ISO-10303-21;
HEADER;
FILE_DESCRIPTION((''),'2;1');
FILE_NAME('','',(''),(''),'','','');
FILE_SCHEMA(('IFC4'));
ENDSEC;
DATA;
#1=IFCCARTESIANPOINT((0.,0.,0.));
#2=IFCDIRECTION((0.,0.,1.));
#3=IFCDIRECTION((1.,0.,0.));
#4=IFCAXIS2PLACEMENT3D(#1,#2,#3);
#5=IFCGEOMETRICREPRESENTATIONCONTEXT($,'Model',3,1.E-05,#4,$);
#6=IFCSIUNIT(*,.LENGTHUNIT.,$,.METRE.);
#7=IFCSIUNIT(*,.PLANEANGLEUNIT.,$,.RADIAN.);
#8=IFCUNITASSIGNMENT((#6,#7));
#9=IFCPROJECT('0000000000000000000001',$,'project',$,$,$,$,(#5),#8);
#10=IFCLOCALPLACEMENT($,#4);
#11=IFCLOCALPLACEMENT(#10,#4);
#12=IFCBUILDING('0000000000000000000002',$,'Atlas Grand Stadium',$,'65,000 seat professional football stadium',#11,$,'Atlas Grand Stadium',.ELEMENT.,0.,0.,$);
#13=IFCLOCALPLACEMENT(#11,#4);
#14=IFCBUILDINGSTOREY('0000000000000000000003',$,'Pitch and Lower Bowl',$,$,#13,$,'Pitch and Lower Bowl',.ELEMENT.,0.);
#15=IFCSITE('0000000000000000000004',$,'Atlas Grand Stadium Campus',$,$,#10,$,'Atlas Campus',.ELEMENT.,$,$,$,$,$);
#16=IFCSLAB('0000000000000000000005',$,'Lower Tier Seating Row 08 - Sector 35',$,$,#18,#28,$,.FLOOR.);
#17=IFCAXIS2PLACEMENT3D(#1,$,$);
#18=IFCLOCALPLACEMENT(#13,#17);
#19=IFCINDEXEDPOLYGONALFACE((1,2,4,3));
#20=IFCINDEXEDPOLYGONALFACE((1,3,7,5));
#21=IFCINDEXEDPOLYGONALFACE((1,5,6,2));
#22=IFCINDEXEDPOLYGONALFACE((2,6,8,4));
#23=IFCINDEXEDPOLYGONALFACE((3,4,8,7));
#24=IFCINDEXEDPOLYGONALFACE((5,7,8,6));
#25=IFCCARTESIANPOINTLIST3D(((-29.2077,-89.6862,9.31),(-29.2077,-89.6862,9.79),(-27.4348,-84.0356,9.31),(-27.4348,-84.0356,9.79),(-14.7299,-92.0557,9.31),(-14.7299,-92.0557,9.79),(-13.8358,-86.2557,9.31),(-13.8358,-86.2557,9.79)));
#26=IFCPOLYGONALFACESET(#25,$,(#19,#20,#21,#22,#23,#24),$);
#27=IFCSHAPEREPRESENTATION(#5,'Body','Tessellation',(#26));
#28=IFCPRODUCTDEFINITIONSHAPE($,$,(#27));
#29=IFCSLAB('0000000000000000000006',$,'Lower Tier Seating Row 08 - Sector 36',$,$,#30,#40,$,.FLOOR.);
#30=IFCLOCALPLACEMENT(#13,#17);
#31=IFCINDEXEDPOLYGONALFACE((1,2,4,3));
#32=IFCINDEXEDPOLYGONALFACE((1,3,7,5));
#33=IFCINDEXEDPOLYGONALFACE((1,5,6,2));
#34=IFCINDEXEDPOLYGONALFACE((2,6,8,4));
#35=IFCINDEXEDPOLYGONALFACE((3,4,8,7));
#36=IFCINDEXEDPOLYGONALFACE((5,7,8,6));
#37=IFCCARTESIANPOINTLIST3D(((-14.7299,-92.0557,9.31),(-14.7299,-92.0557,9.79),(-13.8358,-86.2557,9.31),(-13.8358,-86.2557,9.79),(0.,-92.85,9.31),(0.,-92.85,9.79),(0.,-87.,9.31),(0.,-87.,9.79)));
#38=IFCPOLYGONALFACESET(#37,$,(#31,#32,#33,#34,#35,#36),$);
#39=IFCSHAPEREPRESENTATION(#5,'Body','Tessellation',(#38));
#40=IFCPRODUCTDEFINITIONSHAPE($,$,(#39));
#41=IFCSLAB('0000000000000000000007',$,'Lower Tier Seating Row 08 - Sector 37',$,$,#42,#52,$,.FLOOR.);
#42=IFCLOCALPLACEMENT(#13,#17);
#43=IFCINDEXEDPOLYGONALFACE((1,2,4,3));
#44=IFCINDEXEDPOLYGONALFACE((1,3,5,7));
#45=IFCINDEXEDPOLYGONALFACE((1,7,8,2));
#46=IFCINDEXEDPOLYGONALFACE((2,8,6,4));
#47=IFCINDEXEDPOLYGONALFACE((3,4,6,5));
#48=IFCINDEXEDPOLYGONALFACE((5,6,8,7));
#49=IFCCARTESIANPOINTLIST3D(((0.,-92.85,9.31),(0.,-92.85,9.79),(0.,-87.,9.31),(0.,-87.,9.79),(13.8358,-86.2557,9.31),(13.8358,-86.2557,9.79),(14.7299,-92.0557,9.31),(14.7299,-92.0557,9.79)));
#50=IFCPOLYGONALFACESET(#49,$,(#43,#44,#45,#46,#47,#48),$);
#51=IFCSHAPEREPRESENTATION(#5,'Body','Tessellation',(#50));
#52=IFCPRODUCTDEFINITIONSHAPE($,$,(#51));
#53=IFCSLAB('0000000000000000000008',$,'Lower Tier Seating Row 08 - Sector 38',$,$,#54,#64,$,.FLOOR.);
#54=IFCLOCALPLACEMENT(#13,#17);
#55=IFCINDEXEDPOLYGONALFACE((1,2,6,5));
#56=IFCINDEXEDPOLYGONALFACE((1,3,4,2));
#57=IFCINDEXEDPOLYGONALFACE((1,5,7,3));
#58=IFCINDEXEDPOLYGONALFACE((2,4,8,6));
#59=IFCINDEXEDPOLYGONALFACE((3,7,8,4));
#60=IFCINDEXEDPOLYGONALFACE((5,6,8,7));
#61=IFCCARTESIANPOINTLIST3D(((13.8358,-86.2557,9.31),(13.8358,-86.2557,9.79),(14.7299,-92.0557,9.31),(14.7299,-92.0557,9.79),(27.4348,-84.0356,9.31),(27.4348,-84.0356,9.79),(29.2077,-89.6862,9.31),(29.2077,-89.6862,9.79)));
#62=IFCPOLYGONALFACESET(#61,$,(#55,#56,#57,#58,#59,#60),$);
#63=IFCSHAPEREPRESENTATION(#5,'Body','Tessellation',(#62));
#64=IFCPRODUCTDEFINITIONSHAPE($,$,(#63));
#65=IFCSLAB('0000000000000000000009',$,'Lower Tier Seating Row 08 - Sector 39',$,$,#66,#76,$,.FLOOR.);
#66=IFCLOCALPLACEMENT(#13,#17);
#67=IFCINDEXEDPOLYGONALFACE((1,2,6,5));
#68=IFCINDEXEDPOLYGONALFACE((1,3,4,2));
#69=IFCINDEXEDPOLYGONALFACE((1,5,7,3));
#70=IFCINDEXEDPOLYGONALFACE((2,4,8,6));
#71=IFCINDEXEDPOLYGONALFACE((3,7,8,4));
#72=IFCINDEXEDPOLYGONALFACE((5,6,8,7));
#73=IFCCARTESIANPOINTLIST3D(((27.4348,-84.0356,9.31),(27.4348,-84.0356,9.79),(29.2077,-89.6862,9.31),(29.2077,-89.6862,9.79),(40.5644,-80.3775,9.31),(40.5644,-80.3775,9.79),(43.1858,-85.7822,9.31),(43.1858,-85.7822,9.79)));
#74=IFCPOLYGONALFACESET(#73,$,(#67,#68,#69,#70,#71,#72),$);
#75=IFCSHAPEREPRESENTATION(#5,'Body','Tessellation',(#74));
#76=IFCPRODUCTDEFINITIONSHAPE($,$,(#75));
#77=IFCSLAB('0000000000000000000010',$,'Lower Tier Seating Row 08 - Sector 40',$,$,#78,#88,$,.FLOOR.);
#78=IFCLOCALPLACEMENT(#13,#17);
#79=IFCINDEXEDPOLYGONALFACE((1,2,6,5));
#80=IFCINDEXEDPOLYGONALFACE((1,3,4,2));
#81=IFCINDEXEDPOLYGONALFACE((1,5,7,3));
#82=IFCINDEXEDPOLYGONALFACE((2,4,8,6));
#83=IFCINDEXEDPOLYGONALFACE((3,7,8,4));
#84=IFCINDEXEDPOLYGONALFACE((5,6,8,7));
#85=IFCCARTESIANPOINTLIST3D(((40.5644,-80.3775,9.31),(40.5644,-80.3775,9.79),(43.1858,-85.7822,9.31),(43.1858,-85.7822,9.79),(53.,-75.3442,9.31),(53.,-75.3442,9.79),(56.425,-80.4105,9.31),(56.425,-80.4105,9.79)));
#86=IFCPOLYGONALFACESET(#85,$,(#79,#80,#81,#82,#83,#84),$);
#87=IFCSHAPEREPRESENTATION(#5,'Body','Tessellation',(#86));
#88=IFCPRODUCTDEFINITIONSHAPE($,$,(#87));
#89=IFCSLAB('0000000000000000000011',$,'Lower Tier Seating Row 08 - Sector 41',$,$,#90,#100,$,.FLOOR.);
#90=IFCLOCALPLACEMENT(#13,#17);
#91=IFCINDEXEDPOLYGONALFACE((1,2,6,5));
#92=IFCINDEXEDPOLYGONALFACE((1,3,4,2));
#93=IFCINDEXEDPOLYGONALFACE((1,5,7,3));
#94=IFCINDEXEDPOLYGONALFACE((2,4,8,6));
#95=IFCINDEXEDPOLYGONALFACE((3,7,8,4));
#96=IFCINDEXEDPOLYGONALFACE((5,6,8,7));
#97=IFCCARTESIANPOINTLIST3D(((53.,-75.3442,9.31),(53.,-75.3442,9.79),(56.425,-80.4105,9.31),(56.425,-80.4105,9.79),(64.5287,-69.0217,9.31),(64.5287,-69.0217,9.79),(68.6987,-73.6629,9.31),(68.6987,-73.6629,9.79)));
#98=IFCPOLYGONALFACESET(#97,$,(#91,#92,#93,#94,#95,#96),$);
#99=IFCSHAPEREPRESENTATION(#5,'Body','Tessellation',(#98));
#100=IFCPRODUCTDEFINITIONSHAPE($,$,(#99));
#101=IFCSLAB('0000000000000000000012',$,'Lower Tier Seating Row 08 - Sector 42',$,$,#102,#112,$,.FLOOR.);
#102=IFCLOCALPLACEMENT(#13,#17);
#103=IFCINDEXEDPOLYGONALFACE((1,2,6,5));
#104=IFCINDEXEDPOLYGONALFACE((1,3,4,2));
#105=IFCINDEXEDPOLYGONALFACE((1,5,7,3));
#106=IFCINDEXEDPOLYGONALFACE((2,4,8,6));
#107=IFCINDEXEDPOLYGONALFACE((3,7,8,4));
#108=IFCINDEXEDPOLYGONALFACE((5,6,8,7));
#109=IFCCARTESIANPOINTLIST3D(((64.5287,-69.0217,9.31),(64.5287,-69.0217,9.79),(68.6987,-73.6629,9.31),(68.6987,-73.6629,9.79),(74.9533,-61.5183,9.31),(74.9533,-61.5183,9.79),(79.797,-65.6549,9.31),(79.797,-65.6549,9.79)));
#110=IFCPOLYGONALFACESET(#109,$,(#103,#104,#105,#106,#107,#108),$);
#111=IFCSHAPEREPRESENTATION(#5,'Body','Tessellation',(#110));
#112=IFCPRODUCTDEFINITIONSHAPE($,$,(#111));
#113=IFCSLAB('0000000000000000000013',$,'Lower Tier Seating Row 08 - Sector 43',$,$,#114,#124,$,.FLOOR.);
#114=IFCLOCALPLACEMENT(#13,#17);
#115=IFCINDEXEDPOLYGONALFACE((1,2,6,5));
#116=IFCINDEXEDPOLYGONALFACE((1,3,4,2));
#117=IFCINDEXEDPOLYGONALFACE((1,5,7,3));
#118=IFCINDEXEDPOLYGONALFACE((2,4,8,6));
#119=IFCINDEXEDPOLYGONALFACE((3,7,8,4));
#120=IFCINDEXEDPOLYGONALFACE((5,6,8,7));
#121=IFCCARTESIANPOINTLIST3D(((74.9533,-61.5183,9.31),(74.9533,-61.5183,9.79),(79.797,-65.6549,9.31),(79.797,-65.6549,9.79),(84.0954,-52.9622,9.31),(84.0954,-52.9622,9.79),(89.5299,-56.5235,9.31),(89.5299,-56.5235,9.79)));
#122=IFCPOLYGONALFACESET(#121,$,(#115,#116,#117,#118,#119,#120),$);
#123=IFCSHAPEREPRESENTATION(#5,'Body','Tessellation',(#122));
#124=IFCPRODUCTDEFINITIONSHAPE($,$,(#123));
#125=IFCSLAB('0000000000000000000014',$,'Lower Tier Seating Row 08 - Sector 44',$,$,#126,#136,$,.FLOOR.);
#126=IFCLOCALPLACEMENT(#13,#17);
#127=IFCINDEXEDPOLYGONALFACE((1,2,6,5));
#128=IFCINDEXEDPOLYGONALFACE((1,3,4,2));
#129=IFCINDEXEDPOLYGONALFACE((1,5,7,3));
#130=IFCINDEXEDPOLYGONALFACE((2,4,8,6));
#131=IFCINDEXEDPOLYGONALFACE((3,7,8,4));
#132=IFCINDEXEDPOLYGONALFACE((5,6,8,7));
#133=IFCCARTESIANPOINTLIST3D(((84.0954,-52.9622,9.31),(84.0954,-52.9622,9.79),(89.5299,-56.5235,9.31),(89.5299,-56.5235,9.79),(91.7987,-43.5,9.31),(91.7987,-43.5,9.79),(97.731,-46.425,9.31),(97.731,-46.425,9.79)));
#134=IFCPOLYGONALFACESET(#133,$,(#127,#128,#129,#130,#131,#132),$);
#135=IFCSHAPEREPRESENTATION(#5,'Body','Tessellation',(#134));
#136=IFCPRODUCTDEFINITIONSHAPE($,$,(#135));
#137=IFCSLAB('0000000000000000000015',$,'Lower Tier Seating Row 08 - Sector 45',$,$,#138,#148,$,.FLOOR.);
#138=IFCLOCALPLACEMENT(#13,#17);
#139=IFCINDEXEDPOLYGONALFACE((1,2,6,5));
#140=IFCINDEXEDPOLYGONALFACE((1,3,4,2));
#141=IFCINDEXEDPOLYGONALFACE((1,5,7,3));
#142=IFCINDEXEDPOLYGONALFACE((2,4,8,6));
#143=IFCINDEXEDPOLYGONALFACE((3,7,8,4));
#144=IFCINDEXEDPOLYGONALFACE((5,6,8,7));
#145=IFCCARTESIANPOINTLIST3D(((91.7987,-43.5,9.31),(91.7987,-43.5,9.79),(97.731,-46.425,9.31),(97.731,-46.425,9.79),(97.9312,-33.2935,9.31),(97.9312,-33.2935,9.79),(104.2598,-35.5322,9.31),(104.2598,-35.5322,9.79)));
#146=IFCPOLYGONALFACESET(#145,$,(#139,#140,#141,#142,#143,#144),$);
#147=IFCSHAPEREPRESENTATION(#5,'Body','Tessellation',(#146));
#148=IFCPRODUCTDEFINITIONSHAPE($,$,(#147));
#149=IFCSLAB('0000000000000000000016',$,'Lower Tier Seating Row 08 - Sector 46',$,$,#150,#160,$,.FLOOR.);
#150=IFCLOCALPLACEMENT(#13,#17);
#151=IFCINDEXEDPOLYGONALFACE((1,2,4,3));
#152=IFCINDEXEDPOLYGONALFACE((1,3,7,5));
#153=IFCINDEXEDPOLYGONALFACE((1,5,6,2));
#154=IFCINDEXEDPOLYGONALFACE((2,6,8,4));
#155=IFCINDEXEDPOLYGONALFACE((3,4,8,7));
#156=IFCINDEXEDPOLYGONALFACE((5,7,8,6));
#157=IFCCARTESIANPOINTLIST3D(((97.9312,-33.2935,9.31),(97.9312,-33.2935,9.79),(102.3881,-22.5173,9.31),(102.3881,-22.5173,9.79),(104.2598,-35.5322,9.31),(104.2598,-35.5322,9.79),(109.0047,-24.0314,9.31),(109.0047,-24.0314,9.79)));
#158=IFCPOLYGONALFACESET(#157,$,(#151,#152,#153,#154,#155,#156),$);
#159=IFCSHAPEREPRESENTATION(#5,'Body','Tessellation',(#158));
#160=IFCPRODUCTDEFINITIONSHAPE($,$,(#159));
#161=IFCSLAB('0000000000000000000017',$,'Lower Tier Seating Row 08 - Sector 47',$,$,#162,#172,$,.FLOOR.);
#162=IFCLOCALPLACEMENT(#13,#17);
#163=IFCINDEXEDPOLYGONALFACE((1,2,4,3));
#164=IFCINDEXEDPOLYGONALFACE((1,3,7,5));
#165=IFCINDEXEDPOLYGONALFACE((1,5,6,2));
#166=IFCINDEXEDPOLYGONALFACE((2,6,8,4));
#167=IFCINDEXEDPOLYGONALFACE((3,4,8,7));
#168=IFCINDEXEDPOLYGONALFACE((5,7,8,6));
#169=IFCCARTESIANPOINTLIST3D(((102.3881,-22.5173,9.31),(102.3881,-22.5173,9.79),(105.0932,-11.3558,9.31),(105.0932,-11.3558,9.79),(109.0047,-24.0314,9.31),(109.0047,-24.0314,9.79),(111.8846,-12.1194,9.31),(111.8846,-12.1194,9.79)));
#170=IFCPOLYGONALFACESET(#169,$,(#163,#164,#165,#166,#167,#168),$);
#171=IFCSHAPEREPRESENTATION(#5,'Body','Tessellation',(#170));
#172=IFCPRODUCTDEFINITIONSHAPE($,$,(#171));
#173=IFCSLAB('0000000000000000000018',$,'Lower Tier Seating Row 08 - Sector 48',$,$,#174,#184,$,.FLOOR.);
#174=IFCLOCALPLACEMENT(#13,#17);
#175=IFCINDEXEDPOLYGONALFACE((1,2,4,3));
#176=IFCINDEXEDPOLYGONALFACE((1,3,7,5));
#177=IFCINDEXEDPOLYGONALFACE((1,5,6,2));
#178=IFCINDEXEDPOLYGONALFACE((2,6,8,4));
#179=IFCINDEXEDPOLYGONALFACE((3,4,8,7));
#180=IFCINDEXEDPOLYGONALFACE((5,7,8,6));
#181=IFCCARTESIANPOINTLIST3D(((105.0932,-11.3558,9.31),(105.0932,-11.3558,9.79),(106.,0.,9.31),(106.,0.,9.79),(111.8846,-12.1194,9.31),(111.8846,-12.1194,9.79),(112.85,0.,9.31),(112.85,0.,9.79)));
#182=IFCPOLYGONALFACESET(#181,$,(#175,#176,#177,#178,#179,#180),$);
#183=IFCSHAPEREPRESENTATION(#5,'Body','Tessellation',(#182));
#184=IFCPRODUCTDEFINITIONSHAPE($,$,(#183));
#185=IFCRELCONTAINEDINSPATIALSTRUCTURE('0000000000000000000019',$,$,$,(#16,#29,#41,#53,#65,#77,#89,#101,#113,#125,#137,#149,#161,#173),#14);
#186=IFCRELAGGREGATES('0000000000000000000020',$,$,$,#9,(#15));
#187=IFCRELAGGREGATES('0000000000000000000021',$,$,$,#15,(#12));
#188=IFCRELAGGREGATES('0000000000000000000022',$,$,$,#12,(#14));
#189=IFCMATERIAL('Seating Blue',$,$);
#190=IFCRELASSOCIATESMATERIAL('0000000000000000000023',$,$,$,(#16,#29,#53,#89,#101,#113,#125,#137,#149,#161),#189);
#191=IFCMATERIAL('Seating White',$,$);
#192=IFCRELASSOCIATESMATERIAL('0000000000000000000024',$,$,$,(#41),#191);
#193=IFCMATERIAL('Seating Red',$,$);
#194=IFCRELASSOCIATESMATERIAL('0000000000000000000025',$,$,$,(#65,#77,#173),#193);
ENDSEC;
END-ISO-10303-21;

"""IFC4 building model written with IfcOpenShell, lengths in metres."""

from ifc_helpers import new_model, si_unit, frame, origin_with_axes, place, context, project, spatial, polyline, outline, extrude, material, element, save


model = new_model("IFC4")

# Units and contexts
model_context = context("Model", 3, precision=1e-05, world=origin_with_axes())
ifc_project = project(units=[si_unit("LENGTHUNIT", "METRE"), si_unit("PLANEANGLEUNIT", "RADIAN")], contexts=[model_context])

# Site, building, storey
site_placement = place(None, origin_with_axes())
site = spatial("IfcSite", under=ifc_project, at=site_placement, Name="Atlas Grand Stadium Campus", LongName="Atlas Campus", CompositionType="ELEMENT")
building_placement = place(site_placement, origin_with_axes())
building = spatial("IfcBuilding", under=site, at=building_placement, Name="Atlas Grand Stadium", ObjectType="65,000 seat professional football stadium", LongName="Atlas Grand Stadium", CompositionType="ELEMENT", ElevationOfRefHeight=0.0, ElevationOfTerrain=0.0)
storey_placement = place(building_placement, origin_with_axes())
storey = spatial("IfcBuildingStorey", under=building, at=storey_placement, Name="Pitch and Lower Bowl", LongName="Pitch and Lower Bowl", CompositionType="ELEMENT", Elevation=0.0)

# Slabs
ifc_material_1 = material(Name="Seating Red")
ifc_material_2 = material(Name="Seating Blue")
ifc_material_3 = material(Name="Seating White")
slab_1_placement = place(storey_placement, frame((0.0, 0.0, 9.31), z_axis=(0.0, 0.0, 1.0), x_axis=(1.0, 0.0, 0.0)))
element("IfcSlab", 1, at=slab_1_placement, inside=storey, material=ifc_material_2, Name="Lower Tier Seating Row 08 - Sector 35", PredefinedType="FLOOR", context=model_context, shape_type="SweptSolid", body=[
    extrude(outline(polyline([(-29.2077, -89.6862), (-14.7299, -92.0557), (-13.8358, -86.2557), (-27.4348, -84.0356), (-29.2077, -89.6862)])), origin_with_axes(), (0.0, 0.0, 1.0), 0.48),
])
slab_2_placement = place(storey_placement, frame((0.0, 0.0, 9.31), z_axis=(0.0, 0.0, 1.0), x_axis=(1.0, 0.0, 0.0)))
element("IfcSlab", 2, at=slab_2_placement, inside=storey, material=ifc_material_2, Name="Lower Tier Seating Row 08 - Sector 36", PredefinedType="FLOOR", context=model_context, shape_type="SweptSolid", body=[
    extrude(outline(polyline([(-14.7299, -92.0557), (0.0, -92.85), (0.0, -87.0), (-13.8358, -86.2557), (-14.7299, -92.0557)])), origin_with_axes(), (0.0, 0.0, 1.0), 0.48),
])
slab_3_placement = place(storey_placement, frame((0.0, 0.0, 9.31), z_axis=(0.0, 0.0, 1.0), x_axis=(1.0, 0.0, 0.0)))
element("IfcSlab", 3, at=slab_3_placement, inside=storey, material=ifc_material_3, Name="Lower Tier Seating Row 08 - Sector 37", PredefinedType="FLOOR", context=model_context, shape_type="SweptSolid", body=[
    extrude(outline(polyline([(0.0, -92.85), (14.7299, -92.0557), (13.8358, -86.2557), (0.0, -87.0), (0.0, -92.85)])), origin_with_axes(), (0.0, 0.0, 1.0), 0.48),
])
slab_4_placement = place(storey_placement, frame((0.0, 0.0, 9.31), z_axis=(0.0, 0.0, 1.0), x_axis=(1.0, 0.0, 0.0)))
element("IfcSlab", 4, at=slab_4_placement, inside=storey, material=ifc_material_2, Name="Lower Tier Seating Row 08 - Sector 38", PredefinedType="FLOOR", context=model_context, shape_type="SweptSolid", body=[
    extrude(outline(polyline([(14.7299, -92.0557), (29.2077, -89.6862), (27.4348, -84.0356), (13.8358, -86.2557), (14.7299, -92.0557)])), origin_with_axes(), (0.0, 0.0, 1.0), 0.48),
])
slab_5_placement = place(storey_placement, frame((0.0, 0.0, 9.31), z_axis=(0.0, 0.0, 1.0), x_axis=(1.0, 0.0, 0.0)))
element("IfcSlab", 5, at=slab_5_placement, inside=storey, material=ifc_material_1, Name="Lower Tier Seating Row 08 - Sector 39", PredefinedType="FLOOR", context=model_context, shape_type="SweptSolid", body=[
    extrude(outline(polyline([(29.2077, -89.6862), (43.1858, -85.7822), (40.5644, -80.3775), (27.4348, -84.0356), (29.2077, -89.6862)])), origin_with_axes(), (0.0, 0.0, 1.0), 0.48),
])
slab_6_placement = place(storey_placement, frame((0.0, 0.0, 9.31), z_axis=(0.0, 0.0, 1.0), x_axis=(1.0, 0.0, 0.0)))
element("IfcSlab", 6, at=slab_6_placement, inside=storey, material=ifc_material_1, Name="Lower Tier Seating Row 08 - Sector 40", PredefinedType="FLOOR", context=model_context, shape_type="SweptSolid", body=[
    extrude(outline(polyline([(43.1858, -85.7822), (56.425, -80.4105), (53.0, -75.3442), (40.5644, -80.3775), (43.1858, -85.7822)])), origin_with_axes(), (0.0, 0.0, 1.0), 0.48),
])
slab_7_placement = place(storey_placement, frame((0.0, 0.0, 9.31), z_axis=(0.0, 0.0, 1.0), x_axis=(1.0, 0.0, 0.0)))
element("IfcSlab", 7, at=slab_7_placement, inside=storey, material=ifc_material_2, Name="Lower Tier Seating Row 08 - Sector 41", PredefinedType="FLOOR", context=model_context, shape_type="SweptSolid", body=[
    extrude(outline(polyline([(56.425, -80.4105), (68.6987, -73.6629), (64.5287, -69.0217), (53.0, -75.3442), (56.425, -80.4105)])), origin_with_axes(), (0.0, 0.0, 1.0), 0.48),
])
slab_8_placement = place(storey_placement, frame((0.0, 0.0, 9.31), z_axis=(0.0, 0.0, 1.0), x_axis=(1.0, 0.0, 0.0)))
element("IfcSlab", 8, at=slab_8_placement, inside=storey, material=ifc_material_2, Name="Lower Tier Seating Row 08 - Sector 42", PredefinedType="FLOOR", context=model_context, shape_type="SweptSolid", body=[
    extrude(outline(polyline([(68.6987, -73.6629), (79.797, -65.6549), (74.9533, -61.5183), (64.5287, -69.0217), (68.6987, -73.6629)])), origin_with_axes(), (0.0, 0.0, 1.0), 0.48),
])
slab_9_placement = place(storey_placement, frame((0.0, 0.0, 9.31), z_axis=(0.0, 0.0, 1.0), x_axis=(1.0, 0.0, 0.0)))
element("IfcSlab", 9, at=slab_9_placement, inside=storey, material=ifc_material_2, Name="Lower Tier Seating Row 08 - Sector 43", PredefinedType="FLOOR", context=model_context, shape_type="SweptSolid", body=[
    extrude(outline(polyline([(79.797, -65.6549), (89.5299, -56.5235), (84.0954, -52.9622), (74.9533, -61.5183), (79.797, -65.6549)])), origin_with_axes(), (0.0, 0.0, 1.0), 0.48),
])
slab_10_placement = place(storey_placement, frame((0.0, 0.0, 9.31), z_axis=(0.0, 0.0, 1.0), x_axis=(1.0, 0.0, 0.0)))
element("IfcSlab", 10, at=slab_10_placement, inside=storey, material=ifc_material_2, Name="Lower Tier Seating Row 08 - Sector 44", PredefinedType="FLOOR", context=model_context, shape_type="SweptSolid", body=[
    extrude(outline(polyline([(89.5299, -56.5235), (97.731, -46.425), (91.7987, -43.5), (84.0954, -52.9622), (89.5299, -56.5235)])), origin_with_axes(), (0.0, 0.0, 1.0), 0.48),
])
slab_11_placement = place(storey_placement, frame((0.0, 0.0, 9.31), z_axis=(0.0, 0.0, 1.0), x_axis=(1.0, 0.0, 0.0)))
element("IfcSlab", 11, at=slab_11_placement, inside=storey, material=ifc_material_2, Name="Lower Tier Seating Row 08 - Sector 45", PredefinedType="FLOOR", context=model_context, shape_type="SweptSolid", body=[
    extrude(outline(polyline([(97.731, -46.425), (104.2598, -35.5322), (97.9312, -33.2935), (91.7987, -43.5), (97.731, -46.425)])), origin_with_axes(), (0.0, 0.0, 1.0), 0.48),
])
slab_12_placement = place(storey_placement, frame((0.0, 0.0, 9.31), z_axis=(0.0, 0.0, 1.0), x_axis=(1.0, 0.0, 0.0)))
element("IfcSlab", 12, at=slab_12_placement, inside=storey, material=ifc_material_2, Name="Lower Tier Seating Row 08 - Sector 46", PredefinedType="FLOOR", context=model_context, shape_type="SweptSolid", body=[
    extrude(outline(polyline([(104.2598, -35.5322), (109.0047, -24.0313), (102.3881, -22.5173), (97.9312, -33.2935), (104.2598, -35.5322)])), origin_with_axes(), (0.0, 0.0, 1.0), 0.48),
])
slab_13_placement = place(storey_placement, frame((0.0, 0.0, 9.31), z_axis=(0.0, 0.0, 1.0), x_axis=(1.0, 0.0, 0.0)))
element("IfcSlab", 13, at=slab_13_placement, inside=storey, material=ifc_material_2, Name="Lower Tier Seating Row 08 - Sector 47", PredefinedType="FLOOR", context=model_context, shape_type="SweptSolid", body=[
    extrude(outline(polyline([(109.0047, -24.0313), (111.8846, -12.1194), (105.0932, -11.3558), (102.3881, -22.5173), (109.0047, -24.0313)])), origin_with_axes(), (0.0, 0.0, 1.0), 0.48),
])
slab_14_placement = place(storey_placement, frame((0.0, 0.0, 9.31), z_axis=(0.0, 0.0, 1.0), x_axis=(1.0, 0.0, 0.0)))
element("IfcSlab", 14, at=slab_14_placement, inside=storey, material=ifc_material_1, Name="Lower Tier Seating Row 08 - Sector 48", PredefinedType="FLOOR", context=model_context, shape_type="SweptSolid", body=[
    extrude(outline(polyline([(111.8846, -12.1194), (112.85, 0.0), (106.0, 0.0), (105.0932, -11.3558), (111.8846, -12.1194)])), origin_with_axes(), (0.0, 0.0, 1.0), 0.48),
])

save(model, "model.ifc")
